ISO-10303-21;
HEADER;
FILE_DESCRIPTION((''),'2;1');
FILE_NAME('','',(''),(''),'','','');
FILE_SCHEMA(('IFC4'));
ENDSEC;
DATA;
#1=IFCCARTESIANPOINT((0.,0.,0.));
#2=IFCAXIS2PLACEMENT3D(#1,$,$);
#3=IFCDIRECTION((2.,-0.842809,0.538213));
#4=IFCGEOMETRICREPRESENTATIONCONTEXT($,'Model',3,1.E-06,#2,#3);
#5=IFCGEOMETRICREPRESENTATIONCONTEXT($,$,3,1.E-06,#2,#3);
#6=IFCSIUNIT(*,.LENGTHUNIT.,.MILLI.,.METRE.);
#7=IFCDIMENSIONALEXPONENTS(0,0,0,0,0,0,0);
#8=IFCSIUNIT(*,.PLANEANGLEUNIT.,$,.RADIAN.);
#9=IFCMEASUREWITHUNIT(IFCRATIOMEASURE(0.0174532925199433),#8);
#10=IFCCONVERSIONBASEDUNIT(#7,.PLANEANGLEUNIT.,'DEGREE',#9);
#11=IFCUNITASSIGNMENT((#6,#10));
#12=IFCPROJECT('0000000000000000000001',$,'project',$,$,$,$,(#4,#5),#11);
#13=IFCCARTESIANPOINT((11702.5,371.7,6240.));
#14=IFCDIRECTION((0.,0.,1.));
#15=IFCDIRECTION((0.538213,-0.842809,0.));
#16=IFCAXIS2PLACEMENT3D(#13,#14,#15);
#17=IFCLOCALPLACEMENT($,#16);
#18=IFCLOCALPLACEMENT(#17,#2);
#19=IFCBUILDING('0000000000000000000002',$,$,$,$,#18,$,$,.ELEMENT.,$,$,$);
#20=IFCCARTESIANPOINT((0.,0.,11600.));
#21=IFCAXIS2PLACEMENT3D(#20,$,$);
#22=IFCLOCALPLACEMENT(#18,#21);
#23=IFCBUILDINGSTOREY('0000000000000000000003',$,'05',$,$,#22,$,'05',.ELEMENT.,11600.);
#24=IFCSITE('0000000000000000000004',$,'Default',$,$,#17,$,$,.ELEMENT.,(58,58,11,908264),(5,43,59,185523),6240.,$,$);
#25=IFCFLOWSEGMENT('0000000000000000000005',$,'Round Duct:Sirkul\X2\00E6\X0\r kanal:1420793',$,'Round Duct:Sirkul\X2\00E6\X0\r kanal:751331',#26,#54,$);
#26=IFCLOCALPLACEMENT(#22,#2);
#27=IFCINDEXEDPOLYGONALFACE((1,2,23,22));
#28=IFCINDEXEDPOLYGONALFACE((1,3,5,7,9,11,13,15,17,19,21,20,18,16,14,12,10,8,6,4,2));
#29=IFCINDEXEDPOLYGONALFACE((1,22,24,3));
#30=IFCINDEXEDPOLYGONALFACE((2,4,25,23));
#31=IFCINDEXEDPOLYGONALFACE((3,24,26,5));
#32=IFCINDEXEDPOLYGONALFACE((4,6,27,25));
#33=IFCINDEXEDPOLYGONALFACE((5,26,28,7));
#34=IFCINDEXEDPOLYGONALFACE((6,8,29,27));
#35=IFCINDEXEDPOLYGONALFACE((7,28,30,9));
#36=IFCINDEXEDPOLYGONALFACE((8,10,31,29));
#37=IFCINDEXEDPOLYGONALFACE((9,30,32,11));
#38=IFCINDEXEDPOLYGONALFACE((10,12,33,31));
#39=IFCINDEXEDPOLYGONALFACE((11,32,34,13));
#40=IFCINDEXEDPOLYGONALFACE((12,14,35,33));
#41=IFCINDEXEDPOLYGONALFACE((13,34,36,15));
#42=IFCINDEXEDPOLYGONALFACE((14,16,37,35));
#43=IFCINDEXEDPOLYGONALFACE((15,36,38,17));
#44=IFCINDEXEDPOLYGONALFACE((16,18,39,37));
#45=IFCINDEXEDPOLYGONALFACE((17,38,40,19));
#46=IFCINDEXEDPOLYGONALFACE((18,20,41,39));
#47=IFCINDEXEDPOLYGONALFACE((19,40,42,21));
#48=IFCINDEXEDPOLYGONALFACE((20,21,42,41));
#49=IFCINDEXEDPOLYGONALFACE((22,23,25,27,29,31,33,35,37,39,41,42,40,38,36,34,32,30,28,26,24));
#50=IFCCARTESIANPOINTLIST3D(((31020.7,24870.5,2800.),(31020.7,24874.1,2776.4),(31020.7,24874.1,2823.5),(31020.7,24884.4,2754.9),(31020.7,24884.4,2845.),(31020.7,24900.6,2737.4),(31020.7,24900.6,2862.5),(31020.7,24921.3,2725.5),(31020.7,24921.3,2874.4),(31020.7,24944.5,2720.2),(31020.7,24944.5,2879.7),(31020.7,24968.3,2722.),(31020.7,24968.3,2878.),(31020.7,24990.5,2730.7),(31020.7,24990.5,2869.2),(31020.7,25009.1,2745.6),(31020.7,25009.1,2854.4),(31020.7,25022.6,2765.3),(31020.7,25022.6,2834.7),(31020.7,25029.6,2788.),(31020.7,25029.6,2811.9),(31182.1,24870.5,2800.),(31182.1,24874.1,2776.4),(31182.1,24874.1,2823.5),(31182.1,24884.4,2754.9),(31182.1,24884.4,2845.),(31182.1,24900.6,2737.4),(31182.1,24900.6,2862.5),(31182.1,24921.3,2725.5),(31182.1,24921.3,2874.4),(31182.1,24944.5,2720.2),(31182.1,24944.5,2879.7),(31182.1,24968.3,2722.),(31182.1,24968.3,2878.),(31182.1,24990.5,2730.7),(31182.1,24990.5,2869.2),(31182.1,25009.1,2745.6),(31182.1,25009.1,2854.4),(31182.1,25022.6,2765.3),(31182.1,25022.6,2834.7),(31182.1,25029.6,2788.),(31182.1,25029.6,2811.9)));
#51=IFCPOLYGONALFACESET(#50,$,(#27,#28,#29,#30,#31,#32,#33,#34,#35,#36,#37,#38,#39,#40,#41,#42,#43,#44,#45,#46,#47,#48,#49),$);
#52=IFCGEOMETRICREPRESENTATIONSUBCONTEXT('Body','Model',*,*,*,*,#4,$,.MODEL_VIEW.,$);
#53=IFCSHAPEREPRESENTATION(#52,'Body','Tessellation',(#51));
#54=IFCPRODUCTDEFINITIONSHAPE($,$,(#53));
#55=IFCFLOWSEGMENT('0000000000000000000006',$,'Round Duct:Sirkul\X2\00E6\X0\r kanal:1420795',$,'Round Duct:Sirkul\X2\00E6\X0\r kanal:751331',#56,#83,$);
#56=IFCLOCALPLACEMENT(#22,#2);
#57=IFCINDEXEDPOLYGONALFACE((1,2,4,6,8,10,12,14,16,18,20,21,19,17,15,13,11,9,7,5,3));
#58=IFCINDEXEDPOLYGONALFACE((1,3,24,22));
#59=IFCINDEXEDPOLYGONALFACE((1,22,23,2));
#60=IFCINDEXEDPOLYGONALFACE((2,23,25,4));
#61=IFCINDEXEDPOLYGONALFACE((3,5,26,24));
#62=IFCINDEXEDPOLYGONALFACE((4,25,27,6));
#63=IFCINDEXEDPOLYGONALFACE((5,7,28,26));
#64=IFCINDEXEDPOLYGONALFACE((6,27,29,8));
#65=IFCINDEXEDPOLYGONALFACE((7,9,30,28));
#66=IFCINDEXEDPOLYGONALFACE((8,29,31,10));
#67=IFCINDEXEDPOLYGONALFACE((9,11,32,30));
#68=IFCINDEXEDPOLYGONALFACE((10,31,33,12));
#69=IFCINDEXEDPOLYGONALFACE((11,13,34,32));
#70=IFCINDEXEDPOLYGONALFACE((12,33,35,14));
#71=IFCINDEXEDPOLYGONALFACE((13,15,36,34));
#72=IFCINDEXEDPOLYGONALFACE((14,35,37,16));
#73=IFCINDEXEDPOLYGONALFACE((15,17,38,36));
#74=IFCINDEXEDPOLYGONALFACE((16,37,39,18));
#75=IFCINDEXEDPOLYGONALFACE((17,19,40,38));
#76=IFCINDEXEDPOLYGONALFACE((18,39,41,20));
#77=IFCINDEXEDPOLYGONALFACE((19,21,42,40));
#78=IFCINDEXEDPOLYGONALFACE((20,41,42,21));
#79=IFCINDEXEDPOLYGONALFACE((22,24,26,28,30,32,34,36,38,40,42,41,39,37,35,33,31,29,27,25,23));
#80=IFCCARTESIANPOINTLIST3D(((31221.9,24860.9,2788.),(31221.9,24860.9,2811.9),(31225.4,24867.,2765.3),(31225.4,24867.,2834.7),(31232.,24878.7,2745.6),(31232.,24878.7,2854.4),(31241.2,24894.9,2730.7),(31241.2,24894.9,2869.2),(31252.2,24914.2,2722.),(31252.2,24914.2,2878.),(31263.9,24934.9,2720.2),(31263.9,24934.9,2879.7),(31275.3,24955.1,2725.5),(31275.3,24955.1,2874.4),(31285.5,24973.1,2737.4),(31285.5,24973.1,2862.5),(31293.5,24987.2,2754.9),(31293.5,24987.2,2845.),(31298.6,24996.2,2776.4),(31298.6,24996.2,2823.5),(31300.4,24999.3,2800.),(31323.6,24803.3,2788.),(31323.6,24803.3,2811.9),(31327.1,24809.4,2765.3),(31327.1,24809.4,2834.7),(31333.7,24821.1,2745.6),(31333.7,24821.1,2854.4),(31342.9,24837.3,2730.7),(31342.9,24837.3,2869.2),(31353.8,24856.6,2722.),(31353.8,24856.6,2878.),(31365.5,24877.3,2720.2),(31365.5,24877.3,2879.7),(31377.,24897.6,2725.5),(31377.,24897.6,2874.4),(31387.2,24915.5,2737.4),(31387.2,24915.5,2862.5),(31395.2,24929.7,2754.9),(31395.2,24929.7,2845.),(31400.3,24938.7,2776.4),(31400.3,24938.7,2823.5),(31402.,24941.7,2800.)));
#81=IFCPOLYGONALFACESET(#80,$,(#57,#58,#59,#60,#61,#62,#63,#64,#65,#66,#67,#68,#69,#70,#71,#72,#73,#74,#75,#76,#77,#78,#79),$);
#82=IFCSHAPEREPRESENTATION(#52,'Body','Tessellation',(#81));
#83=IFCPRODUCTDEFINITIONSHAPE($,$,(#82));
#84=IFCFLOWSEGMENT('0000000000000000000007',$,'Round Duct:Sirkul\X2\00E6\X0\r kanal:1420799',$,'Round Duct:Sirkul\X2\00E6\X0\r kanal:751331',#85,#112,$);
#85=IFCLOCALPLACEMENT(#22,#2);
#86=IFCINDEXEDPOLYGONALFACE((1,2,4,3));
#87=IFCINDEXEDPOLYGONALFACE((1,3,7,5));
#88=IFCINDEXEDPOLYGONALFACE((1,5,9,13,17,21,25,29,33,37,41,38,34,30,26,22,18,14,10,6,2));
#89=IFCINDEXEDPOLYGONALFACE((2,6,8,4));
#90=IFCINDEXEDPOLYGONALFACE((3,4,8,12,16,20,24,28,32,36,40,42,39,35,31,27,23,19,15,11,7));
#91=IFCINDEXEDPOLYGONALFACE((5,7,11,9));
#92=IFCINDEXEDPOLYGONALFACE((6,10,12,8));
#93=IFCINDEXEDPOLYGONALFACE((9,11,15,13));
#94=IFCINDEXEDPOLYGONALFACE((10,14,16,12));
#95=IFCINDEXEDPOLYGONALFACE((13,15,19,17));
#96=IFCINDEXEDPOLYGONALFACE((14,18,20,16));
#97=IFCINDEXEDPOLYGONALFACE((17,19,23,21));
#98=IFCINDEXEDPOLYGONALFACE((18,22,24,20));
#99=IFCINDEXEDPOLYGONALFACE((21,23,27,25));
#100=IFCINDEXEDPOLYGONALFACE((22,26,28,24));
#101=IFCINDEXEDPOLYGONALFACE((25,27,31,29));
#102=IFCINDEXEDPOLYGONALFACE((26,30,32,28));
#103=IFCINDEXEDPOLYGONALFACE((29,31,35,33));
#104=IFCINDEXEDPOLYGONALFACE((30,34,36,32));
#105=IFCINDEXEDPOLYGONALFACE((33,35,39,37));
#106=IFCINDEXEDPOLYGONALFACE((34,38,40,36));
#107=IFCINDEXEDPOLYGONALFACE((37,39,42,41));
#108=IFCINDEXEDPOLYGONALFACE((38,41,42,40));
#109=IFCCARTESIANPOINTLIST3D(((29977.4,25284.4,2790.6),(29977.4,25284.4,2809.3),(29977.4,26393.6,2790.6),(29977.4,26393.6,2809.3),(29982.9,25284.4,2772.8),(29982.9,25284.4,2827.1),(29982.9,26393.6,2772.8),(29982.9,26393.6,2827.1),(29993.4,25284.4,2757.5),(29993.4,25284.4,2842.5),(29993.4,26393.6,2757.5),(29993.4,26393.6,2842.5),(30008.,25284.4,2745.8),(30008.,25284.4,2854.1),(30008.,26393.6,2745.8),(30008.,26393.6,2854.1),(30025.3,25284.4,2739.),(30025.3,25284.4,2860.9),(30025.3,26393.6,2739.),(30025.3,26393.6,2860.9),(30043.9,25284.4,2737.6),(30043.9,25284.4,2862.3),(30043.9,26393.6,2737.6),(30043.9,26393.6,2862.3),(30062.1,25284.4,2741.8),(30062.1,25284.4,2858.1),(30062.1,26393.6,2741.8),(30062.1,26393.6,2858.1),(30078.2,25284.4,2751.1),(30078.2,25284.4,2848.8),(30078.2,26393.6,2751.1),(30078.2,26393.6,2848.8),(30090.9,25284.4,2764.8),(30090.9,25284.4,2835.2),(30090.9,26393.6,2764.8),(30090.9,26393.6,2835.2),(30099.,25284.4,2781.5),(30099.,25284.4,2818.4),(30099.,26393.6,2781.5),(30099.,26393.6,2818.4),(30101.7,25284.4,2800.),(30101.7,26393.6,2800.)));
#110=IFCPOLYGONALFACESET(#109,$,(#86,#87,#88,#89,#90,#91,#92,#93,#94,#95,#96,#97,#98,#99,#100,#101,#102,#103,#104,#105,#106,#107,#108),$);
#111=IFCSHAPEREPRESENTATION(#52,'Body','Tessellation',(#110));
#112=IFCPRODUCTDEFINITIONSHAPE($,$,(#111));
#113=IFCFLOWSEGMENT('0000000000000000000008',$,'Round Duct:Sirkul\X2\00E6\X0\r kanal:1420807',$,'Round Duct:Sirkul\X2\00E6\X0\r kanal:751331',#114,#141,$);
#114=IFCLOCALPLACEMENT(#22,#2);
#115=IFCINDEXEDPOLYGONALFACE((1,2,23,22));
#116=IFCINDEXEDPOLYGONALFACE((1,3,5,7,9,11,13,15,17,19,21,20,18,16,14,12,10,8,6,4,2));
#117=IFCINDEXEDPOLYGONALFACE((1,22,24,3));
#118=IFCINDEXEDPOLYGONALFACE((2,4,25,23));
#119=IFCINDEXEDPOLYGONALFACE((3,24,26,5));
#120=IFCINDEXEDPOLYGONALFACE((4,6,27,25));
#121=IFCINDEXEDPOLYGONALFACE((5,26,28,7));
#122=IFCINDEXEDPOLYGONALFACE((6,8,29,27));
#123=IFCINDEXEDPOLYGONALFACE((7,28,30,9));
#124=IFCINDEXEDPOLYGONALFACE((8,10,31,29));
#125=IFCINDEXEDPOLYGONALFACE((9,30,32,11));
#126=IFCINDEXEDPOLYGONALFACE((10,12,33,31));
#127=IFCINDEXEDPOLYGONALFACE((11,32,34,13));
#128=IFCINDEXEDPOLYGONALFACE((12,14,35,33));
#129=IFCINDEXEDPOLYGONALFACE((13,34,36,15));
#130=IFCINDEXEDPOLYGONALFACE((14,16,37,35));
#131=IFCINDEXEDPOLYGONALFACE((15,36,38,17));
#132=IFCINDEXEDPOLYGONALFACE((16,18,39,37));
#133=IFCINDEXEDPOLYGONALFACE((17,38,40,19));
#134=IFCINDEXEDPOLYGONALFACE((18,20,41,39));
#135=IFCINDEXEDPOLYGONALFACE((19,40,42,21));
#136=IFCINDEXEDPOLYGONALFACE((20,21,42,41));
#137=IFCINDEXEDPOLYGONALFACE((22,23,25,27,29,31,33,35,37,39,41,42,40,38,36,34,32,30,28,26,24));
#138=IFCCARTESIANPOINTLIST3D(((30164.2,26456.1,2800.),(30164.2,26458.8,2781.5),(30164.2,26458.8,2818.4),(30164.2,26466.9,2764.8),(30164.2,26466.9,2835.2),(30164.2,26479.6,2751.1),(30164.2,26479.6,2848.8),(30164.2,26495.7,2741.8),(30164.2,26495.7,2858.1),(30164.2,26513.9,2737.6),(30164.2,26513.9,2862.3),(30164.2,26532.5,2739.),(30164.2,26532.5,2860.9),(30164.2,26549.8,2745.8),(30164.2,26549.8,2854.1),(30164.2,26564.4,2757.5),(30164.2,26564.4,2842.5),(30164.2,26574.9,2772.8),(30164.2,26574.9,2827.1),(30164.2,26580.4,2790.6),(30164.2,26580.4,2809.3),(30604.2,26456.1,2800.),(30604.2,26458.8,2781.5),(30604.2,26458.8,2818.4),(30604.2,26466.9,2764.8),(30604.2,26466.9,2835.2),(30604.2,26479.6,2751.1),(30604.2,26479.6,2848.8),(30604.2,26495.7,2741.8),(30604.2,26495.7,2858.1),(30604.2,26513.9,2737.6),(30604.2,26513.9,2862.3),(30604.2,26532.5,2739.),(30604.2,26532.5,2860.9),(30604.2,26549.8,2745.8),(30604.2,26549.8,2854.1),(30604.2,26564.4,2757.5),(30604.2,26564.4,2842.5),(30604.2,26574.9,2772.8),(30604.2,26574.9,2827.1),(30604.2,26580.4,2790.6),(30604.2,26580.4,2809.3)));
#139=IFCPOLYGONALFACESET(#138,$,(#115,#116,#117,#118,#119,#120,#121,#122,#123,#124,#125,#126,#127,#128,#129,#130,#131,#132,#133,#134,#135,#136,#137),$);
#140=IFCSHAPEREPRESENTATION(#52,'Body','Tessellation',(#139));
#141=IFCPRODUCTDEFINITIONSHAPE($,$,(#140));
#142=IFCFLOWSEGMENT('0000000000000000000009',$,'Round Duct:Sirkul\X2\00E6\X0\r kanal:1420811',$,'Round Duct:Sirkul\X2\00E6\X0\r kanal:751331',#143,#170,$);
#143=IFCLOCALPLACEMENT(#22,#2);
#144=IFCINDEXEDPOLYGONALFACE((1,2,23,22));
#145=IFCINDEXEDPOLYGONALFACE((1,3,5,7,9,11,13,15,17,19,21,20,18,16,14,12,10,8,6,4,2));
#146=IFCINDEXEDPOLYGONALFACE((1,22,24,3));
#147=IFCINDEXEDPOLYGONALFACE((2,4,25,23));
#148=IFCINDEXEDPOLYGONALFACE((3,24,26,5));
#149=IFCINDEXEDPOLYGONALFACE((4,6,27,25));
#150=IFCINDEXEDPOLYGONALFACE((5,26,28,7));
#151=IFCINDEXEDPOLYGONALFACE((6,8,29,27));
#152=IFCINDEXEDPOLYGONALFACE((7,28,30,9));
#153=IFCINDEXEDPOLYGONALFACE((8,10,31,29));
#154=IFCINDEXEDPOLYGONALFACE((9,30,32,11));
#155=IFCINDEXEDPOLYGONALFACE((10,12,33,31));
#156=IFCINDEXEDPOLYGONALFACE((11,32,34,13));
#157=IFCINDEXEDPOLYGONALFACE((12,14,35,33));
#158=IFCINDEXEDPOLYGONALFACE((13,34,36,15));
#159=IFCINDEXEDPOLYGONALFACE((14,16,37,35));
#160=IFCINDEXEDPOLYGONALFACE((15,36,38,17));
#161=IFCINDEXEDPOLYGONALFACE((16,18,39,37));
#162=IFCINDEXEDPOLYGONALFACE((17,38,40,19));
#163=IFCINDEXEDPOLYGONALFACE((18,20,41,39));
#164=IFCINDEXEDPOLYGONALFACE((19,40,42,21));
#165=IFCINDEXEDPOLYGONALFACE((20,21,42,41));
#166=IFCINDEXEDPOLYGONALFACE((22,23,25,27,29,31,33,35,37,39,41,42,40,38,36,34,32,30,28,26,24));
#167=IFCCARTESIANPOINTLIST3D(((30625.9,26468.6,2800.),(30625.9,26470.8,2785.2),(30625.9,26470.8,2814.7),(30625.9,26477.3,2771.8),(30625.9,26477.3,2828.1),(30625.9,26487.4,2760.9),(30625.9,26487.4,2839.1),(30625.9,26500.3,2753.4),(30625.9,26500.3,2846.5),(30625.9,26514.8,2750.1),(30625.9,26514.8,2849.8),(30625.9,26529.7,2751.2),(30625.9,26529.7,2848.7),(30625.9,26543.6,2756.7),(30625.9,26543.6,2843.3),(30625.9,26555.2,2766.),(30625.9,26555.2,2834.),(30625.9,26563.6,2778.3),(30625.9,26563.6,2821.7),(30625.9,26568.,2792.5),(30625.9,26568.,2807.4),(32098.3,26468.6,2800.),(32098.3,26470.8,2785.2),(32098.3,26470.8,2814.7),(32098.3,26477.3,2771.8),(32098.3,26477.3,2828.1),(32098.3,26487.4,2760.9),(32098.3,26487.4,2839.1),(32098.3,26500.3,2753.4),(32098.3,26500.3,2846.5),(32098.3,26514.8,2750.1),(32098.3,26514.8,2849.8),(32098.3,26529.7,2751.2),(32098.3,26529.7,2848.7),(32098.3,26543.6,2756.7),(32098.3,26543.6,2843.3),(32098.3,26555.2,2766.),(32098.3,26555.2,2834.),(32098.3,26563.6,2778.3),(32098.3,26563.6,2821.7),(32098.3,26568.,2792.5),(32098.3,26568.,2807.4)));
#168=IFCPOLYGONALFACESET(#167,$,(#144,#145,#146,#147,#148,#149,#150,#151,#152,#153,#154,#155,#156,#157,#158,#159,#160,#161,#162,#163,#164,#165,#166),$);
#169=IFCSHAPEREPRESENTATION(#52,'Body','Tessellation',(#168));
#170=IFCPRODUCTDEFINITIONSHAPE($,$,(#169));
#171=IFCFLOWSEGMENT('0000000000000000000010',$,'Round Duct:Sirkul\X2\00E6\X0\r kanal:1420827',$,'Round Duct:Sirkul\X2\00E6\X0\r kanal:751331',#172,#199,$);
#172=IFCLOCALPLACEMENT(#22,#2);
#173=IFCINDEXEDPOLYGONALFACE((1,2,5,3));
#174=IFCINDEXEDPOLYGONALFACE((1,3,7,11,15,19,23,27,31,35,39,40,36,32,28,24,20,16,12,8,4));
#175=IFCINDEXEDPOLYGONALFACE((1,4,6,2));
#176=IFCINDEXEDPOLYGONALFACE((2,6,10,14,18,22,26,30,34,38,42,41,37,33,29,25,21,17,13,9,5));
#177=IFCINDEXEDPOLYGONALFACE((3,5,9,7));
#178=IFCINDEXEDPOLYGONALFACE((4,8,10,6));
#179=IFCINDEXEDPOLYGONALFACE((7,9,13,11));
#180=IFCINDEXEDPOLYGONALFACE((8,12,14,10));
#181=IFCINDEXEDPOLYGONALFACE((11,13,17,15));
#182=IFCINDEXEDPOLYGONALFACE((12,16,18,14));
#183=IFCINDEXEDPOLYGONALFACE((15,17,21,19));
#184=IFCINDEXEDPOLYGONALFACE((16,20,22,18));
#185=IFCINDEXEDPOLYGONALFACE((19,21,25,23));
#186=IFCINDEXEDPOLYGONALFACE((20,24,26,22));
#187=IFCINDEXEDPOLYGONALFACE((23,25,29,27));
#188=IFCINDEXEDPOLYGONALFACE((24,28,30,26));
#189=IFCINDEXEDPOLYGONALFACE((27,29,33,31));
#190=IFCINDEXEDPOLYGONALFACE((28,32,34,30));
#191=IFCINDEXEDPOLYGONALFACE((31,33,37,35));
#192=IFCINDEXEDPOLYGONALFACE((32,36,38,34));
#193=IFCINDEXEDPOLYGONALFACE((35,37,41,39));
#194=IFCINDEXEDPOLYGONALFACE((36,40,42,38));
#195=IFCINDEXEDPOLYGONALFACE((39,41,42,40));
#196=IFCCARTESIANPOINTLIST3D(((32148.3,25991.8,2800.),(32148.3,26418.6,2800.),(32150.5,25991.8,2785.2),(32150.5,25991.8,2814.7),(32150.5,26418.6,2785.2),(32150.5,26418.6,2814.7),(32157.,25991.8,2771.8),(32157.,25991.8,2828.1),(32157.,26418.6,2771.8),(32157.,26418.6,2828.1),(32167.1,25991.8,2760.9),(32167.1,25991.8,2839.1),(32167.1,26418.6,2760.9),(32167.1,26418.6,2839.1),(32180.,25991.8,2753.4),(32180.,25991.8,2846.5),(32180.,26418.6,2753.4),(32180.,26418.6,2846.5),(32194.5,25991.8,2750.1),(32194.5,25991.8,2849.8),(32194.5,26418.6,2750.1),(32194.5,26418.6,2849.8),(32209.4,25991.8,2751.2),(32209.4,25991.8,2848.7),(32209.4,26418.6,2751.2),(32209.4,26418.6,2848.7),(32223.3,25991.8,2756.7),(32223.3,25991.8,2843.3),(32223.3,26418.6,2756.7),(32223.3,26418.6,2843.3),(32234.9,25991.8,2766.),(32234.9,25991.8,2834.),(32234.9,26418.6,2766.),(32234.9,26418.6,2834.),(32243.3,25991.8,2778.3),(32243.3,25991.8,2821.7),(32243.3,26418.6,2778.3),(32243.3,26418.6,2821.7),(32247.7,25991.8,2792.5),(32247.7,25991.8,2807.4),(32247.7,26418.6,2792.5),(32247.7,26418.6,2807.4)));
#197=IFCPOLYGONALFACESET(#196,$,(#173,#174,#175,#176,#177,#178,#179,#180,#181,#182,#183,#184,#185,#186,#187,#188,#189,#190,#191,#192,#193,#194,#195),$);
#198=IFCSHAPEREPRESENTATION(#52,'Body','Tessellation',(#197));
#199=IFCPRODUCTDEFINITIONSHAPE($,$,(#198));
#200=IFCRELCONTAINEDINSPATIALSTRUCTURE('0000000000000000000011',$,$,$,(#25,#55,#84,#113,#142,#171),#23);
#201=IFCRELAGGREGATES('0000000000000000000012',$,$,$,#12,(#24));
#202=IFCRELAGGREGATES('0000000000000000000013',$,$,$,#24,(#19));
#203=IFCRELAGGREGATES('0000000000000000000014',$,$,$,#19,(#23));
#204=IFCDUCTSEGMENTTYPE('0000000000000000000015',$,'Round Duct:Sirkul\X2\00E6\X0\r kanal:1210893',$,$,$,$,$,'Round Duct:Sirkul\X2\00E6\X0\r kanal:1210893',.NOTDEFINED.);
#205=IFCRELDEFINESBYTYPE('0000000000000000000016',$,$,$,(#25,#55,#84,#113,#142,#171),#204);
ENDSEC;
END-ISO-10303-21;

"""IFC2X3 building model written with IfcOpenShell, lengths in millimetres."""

from ifc_helpers import new_model, entity, si_unit, converted_unit, direction, frame, frame_2d, origin, origin_2d_with_axis, place, context, subcontext, project, spatial, circle, extrude, type_object, element, save


model = new_model("IFC2X3")

# Units and contexts
model_context = context("Model", 3, precision=1e-06, world=origin(), true_north=direction((2.0, -0.842809, 0.538213)))
context_of_model = context(None, 3, precision=1e-06, world=origin(), true_north=direction((2.0, -0.842809, 0.538213)))
body_context = subcontext(model_context, "Body", "Model", "MODEL_VIEW")
ifc_project = project(units=[si_unit("LENGTHUNIT", "METRE", prefix="MILLI"), converted_unit("PLANEANGLEUNIT", "DEGREE", entity("IfcRatioMeasure", 0.0174532925199433), si_unit("PLANEANGLEUNIT", "RADIAN"), dimensions=[0, 0, 0, 0, 0, 0, 0])], contexts=[model_context, context_of_model])

# Site, building, storey
site_placement = place(None, frame((11702.5, 371.7, 6240.0), z_axis=(0.0, 0.0, 1.0), x_axis=(0.538213, -0.842809, 0.0)))
site = spatial("IfcSite", under=ifc_project, at=site_placement, Name="Default", CompositionType="ELEMENT", RefLatitude=(58, 58, 11, 908264), RefLongitude=(5, 43, 59, 185523), RefElevation=6240.0)
building_placement = place(site_placement, origin())
building = spatial("IfcBuilding", under=site, at=building_placement, CompositionType="ELEMENT")
storey_placement = place(building_placement, frame((0.0, 0.0, 11600.0)))
storey = spatial("IfcBuildingStorey", under=building, at=storey_placement, Name="05", LongName="05", CompositionType="ELEMENT", Elevation=11600.0)

# Flow segments
duct_segment_type = type_object("IfcDuctSegmentType", Name="Round Duct:Sirkulær kanal:1210893", ElementType="Round Duct:Sirkulær kanal:1210893", PredefinedType="NOTDEFINED")
flow_segment_1_placement = place(storey_placement, origin())
element("IfcFlowSegment", 1, at=flow_segment_1_placement, inside=storey, type_object=duct_segment_type, Name="Round Duct:Sirkulær kanal:1420793", ObjectType="Round Duct:Sirkulær kanal:751331", context=body_context, shape_type="SweptSolid", body=[
    extrude(circle(Radius=80.0, at=origin_2d_with_axis()), frame((31020.7, 24950.5, 2800.0), z_axis=(1.0, 0.0, 0.0), x_axis=(0.0, -1.0, 0.0)), (0.0, 0.0, 1.0), 161.4),
])
flow_segment_2_placement = place(storey_placement, origin())
element("IfcFlowSegment", 2, at=flow_segment_2_placement, inside=storey, type_object=duct_segment_type, Name="Round Duct:Sirkulær kanal:1420795", ObjectType="Round Duct:Sirkulær kanal:751331", context=body_context, shape_type="SweptSolid", body=[
    extrude(circle(Radius=80.0, at=origin_2d_with_axis()), frame((31260.9, 24929.7, 2800.0), z_axis=(0.870101, -0.492874, 0.0), x_axis=(0.492874, 0.870101, 0.0)), (0.0, 0.0, 1.0), 116.8),
])
flow_segment_3_placement = place(storey_placement, origin())
element("IfcFlowSegment", 3, at=flow_segment_3_placement, inside=storey, type_object=duct_segment_type, Name="Round Duct:Sirkulær kanal:1420799", ObjectType="Round Duct:Sirkulær kanal:751331", context=body_context, shape_type="SweptSolid", body=[
    extrude(circle(Radius=62.5, at=frame_2d((0.0, 0.0), x_axis=(1.0, 0.0))), frame((30039.2, 25284.4, 2800.0), z_axis=(0.0, 1.0, 0.0), x_axis=(1.0, 0.0, 0.0)), (0.0, 0.0, 1.0), 1109.2),
])
flow_segment_4_placement = place(storey_placement, origin())
element("IfcFlowSegment", 4, at=flow_segment_4_placement, inside=storey, type_object=duct_segment_type, Name="Round Duct:Sirkulær kanal:1420807", ObjectType="Round Duct:Sirkulær kanal:751331", context=body_context, shape_type="SweptSolid", body=[
    extrude(circle(Radius=62.5, at=origin_2d_with_axis()), frame((30164.2, 26518.6, 2800.0), z_axis=(1.0, 0.0, 0.0), x_axis=(0.0, -1.0, 0.0)), (0.0, 0.0, 1.0), 440.0),
])
flow_segment_5_placement = place(storey_placement, origin())
element("IfcFlowSegment", 5, at=flow_segment_5_placement, inside=storey, type_object=duct_segment_type, Name="Round Duct:Sirkulær kanal:1420811", ObjectType="Round Duct:Sirkulær kanal:751331", context=body_context, shape_type="SweptSolid", body=[
    extrude(circle(Radius=50.0, at=frame_2d((0.0, 0.0), x_axis=(1.0, 0.0))), frame((30625.9, 26518.6, 2800.0), z_axis=(1.0, 0.0, 0.0), x_axis=(0.0, -1.0, 0.0)), (0.0, 0.0, 1.0), 1472.4),
])
flow_segment_6_placement = place(storey_placement, origin())
element("IfcFlowSegment", 6, at=flow_segment_6_placement, inside=storey, type_object=duct_segment_type, Name="Round Duct:Sirkulær kanal:1420827", ObjectType="Round Duct:Sirkulær kanal:751331", context=body_context, shape_type="SweptSolid", body=[
    extrude(circle(Radius=50.0, at=origin_2d_with_axis()), frame((32198.3, 25991.8, 2800.0), z_axis=(0.0, 1.0, 0.0), x_axis=(-1.0, 0.0, 0.0)), (0.0, 0.0, 1.0), 426.7),
])

save(model, "model.ifc")
